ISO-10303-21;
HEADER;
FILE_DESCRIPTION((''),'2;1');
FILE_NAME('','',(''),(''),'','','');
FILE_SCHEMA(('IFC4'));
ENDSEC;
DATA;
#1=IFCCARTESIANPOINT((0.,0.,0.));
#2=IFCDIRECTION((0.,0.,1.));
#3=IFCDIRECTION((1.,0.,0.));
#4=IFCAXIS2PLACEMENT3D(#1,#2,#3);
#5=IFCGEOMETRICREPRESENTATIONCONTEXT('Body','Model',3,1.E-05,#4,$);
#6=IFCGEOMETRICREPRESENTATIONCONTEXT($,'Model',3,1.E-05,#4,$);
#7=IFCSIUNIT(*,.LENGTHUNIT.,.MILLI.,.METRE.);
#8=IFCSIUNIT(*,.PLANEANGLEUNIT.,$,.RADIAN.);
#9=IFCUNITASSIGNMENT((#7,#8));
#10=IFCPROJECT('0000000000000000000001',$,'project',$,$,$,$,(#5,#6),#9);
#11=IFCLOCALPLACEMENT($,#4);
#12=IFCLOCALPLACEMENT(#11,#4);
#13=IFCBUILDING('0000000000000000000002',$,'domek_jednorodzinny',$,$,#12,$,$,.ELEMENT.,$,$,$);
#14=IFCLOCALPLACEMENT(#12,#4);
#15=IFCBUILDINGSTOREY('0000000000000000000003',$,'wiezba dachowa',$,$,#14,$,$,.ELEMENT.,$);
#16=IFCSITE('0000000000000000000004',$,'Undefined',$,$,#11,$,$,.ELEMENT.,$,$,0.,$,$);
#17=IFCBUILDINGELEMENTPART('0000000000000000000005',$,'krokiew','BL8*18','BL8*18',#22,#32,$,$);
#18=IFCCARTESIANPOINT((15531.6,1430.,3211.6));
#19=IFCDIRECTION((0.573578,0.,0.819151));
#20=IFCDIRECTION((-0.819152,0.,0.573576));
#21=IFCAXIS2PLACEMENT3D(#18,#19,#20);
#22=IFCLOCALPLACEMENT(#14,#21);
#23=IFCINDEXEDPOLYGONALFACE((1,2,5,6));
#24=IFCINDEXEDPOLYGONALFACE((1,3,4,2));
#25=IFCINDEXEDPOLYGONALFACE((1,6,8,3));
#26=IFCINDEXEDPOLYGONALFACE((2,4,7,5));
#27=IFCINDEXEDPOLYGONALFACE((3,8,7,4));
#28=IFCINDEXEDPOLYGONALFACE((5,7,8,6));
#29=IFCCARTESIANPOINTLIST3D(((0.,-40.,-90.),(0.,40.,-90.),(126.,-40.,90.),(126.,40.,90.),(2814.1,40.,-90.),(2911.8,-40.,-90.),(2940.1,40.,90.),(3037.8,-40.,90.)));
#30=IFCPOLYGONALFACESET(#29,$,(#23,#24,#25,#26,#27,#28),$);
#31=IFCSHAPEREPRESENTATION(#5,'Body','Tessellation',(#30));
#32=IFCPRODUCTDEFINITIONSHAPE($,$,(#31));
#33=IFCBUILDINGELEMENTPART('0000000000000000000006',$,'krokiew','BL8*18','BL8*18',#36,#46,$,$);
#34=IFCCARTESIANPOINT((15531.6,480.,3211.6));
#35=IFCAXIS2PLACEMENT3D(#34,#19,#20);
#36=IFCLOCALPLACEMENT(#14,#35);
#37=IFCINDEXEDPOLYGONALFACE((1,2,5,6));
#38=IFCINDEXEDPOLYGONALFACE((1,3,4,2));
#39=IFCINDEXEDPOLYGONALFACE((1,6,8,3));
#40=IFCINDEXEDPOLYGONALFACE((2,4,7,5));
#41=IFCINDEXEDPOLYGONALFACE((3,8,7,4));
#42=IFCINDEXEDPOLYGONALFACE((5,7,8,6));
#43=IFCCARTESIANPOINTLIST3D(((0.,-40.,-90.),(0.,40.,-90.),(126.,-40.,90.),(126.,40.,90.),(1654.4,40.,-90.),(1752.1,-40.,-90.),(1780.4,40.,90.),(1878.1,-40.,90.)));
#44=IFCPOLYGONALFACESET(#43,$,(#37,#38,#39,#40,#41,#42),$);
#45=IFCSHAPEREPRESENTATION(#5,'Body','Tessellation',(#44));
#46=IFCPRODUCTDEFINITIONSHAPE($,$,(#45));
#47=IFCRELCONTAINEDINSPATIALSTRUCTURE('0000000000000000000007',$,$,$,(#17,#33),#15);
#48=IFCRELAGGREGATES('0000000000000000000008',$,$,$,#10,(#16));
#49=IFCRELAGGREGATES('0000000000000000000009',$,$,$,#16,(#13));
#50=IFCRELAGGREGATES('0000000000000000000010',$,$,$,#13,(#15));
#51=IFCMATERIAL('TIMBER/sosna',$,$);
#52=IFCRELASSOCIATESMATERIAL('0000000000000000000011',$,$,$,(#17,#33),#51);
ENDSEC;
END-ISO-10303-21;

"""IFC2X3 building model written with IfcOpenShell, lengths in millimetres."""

from ifc_helpers import new_model, si_unit, frame, origin_with_axes, origin_2d_with_axis, place, context, project, spatial, rectangle, extrude, clip, halfspace, material, element, save


model = new_model("IFC2X3")

# Units and contexts
model_context_1 = context("Model", 3, precision=1e-05, world=origin_with_axes(), identifier="Body")
model_context_2 = context("Model", 3, precision=1e-05, world=origin_with_axes())
ifc_project = project(units=[si_unit("LENGTHUNIT", "METRE", prefix="MILLI"), si_unit("PLANEANGLEUNIT", "RADIAN")], contexts=[model_context_1, model_context_2])

# Site, building, storey
site_placement = place(None, origin_with_axes())
site = spatial("IfcSite", under=ifc_project, at=site_placement, Name="Undefined", CompositionType="ELEMENT", RefElevation=0.0)
building_placement = place(site_placement, origin_with_axes())
building = spatial("IfcBuilding", under=site, at=building_placement, Name="domek_jednorodzinny", CompositionType="ELEMENT")
storey_placement = place(building_placement, origin_with_axes())
storey = spatial("IfcBuildingStorey", under=building, at=storey_placement, Name="wiezba dachowa", CompositionType="ELEMENT")

# Building element parts
ifc_material = material(Name="TIMBER/sosna")
building_element_part_1_placement = place(storey_placement, frame((15531.6, 1430.0, 3211.6), z_axis=(0.573578, 0.0, 0.819151), x_axis=(-0.819152, 0.0, 0.573576)))
element("IfcBuildingElementPart", 1, at=building_element_part_1_placement, inside=storey, material=ifc_material, Name="krokiew", Description="BL8*18", ObjectType="BL8*18", context=model_context_1, shape_type="Clipping", body=[
    clip(clip(extrude(rectangle(XDim=80.0, YDim=180.0, at=origin_2d_with_axis()), frame((3341.8, 0.0, 0.0), z_axis=(-1.0, 0.0, 0.0), x_axis=(0.0, -1.0, 0.0)), (0.0, 0.0, 1.0), 3341.8), halfspace(frame((0.0, -40.0, -90.0), z_axis=(-0.819152, 0.0, 0.573576), x_axis=(0.0, 1.0, 0.0)), False)), halfspace(frame((2814.1, 40.0, -90.0), z_axis=(0.579226, 0.707109, -0.405579), x_axis=(0.773591, -0.633685, 0.0)), False)),
])
building_element_part_2_placement = place(storey_placement, frame((15531.6, 480.0, 3211.6), z_axis=(0.573578, 0.0, 0.819151), x_axis=(-0.819152, 0.0, 0.573576)))
element("IfcBuildingElementPart", 2, at=building_element_part_2_placement, inside=storey, material=ifc_material, Name="krokiew", Description="BL8*18", ObjectType="BL8*18", context=model_context_1, shape_type="Clipping", body=[
    clip(clip(extrude(rectangle(XDim=80.0, YDim=180.0, at=origin_2d_with_axis()), frame((2341.8, 0.0, 0.0), z_axis=(-1.0, 0.0, 0.0), x_axis=(0.0, -1.0, 0.0)), (0.0, 0.0, 1.0), 2341.8), halfspace(frame((0.0, -40.0, -90.0), z_axis=(-0.819152, 0.0, 0.573576), x_axis=(0.0, 1.0, 0.0)), False)), halfspace(frame((1654.4, 40.0, -90.0), z_axis=(0.578971, 0.70742, -0.4054), x_axis=(0.773864, -0.633351, 0.0)), False)),
])

save(model, "model.ifc")
